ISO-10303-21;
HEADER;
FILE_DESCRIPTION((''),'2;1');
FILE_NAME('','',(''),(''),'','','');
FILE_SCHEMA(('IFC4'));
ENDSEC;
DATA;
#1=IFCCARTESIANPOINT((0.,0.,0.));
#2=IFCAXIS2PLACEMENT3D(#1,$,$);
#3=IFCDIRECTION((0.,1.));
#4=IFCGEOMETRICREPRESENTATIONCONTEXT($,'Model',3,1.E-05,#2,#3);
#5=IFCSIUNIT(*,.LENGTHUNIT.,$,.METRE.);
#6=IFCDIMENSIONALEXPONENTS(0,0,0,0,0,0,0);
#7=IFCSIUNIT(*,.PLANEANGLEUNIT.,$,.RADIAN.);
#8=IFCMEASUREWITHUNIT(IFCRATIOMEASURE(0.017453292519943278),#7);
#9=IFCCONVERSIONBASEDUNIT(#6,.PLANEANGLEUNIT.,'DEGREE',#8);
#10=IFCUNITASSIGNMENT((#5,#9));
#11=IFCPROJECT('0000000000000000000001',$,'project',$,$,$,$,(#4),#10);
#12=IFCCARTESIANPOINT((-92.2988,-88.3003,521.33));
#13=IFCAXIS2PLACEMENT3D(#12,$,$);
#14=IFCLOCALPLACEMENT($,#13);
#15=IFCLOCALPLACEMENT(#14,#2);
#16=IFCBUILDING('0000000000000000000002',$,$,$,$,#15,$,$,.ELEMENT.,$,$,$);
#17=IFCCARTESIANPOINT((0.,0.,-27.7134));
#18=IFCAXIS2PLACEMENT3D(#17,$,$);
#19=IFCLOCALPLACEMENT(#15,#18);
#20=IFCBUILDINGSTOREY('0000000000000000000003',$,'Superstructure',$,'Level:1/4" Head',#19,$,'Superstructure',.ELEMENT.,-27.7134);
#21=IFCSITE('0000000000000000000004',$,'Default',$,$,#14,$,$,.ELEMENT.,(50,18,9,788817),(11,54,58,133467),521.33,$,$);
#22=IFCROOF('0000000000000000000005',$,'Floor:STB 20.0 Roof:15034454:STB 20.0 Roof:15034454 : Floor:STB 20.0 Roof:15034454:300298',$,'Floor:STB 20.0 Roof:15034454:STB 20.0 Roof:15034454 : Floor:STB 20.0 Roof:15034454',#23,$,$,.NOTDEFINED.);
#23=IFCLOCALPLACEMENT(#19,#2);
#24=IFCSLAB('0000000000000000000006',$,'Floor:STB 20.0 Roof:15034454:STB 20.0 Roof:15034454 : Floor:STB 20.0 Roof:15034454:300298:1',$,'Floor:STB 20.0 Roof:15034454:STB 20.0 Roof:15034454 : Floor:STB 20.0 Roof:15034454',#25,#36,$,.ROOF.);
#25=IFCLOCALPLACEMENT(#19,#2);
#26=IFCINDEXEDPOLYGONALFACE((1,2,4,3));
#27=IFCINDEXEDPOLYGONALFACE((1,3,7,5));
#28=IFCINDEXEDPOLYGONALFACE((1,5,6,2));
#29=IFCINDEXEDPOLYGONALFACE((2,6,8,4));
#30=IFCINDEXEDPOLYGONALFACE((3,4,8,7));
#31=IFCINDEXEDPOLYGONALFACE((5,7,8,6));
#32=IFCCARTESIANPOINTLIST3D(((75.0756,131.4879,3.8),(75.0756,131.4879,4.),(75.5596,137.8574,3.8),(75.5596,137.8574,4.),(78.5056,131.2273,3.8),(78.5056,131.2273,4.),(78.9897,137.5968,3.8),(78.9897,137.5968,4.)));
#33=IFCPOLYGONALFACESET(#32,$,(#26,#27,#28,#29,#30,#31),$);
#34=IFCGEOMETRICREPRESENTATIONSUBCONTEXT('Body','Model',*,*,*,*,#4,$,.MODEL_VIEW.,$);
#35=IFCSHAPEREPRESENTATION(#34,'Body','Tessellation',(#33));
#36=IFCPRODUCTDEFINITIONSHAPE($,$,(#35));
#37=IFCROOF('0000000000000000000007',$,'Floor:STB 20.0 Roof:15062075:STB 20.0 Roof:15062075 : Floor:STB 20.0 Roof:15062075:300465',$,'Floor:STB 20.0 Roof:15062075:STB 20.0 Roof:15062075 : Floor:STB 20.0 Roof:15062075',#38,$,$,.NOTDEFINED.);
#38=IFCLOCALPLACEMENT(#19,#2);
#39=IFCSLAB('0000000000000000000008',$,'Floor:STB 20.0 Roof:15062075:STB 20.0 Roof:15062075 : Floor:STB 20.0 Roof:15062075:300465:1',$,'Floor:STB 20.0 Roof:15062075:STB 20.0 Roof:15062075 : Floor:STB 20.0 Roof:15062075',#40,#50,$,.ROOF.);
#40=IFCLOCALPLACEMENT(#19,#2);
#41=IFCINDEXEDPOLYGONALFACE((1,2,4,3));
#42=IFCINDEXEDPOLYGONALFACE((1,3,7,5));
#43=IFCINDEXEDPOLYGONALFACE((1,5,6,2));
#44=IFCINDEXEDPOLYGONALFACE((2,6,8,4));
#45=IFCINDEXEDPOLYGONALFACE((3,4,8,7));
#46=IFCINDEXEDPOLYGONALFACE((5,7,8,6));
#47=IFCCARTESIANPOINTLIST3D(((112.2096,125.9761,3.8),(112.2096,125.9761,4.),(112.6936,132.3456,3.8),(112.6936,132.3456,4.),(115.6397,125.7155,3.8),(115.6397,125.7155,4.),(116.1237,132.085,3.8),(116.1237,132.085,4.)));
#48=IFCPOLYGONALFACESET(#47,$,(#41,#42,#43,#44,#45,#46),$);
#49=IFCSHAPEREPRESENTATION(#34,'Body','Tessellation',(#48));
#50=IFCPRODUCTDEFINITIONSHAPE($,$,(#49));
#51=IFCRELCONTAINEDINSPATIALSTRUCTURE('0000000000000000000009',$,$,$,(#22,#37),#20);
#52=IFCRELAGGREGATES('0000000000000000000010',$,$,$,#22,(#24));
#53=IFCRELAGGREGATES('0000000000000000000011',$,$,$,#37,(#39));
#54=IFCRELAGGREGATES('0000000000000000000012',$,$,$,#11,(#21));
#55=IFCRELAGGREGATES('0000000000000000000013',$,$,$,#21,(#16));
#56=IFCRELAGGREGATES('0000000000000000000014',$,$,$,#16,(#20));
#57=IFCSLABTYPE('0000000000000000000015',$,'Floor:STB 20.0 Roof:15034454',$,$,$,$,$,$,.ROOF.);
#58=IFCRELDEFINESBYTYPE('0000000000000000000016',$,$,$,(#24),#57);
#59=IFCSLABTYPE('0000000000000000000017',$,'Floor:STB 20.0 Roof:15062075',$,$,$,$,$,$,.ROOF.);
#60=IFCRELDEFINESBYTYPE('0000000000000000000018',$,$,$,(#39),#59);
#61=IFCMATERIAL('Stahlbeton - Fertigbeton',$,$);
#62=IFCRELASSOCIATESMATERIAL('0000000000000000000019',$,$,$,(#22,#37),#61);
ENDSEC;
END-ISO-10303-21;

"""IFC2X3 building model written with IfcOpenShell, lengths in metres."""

from ifc_helpers import new_model, entity, si_unit, converted_unit, direction, frame, frame_2d, origin, place, context, subcontext, project, spatial, rectangle, extrude, material, type_object, element, aggregate, save


model = new_model("IFC2X3")

# Units and contexts
model_context = context("Model", 3, precision=1e-05, world=origin(), true_north=direction((0.0, 1.0)))
body_context = subcontext(model_context, "Body", "Model", "MODEL_VIEW")
ifc_project = project(units=[si_unit("LENGTHUNIT", "METRE"), converted_unit("PLANEANGLEUNIT", "DEGREE", entity("IfcRatioMeasure", 0.017453292519943278), si_unit("PLANEANGLEUNIT", "RADIAN"), dimensions=[0, 0, 0, 0, 0, 0, 0])], contexts=[model_context])

# Site, building, storey
site_placement = place(None, frame((-92.2988, -88.3003, 521.33)))
site = spatial("IfcSite", under=ifc_project, at=site_placement, Name="Default", CompositionType="ELEMENT", RefLatitude=(50, 18, 9, 788817), RefLongitude=(11, 54, 58, 133467), RefElevation=521.33)
building_placement = place(site_placement, origin())
building = spatial("IfcBuilding", under=site, at=building_placement, CompositionType="ELEMENT")
storey_placement = place(building_placement, frame((0.0, 0.0, -27.7134)))
storey = spatial("IfcBuildingStorey", under=building, at=storey_placement, Name="Superstructure", ObjectType="Level:1/4\" Head", LongName="Superstructure", CompositionType="ELEMENT", Elevation=-27.7134)

# Roofs, slabs
ifc_material_1 = material(Name="Stahlbeton - Fertigbeton")
roof_1_placement = place(storey_placement, origin())
roof_1 = element("IfcRoof", 1, at=roof_1_placement, inside=storey, material=ifc_material_1, Name="Floor:STB 20.0 Roof:15034454:STB 20.0 Roof:15034454 : Floor:STB 20.0 Roof:15034454:300298", ObjectType="Floor:STB 20.0 Roof:15034454:STB 20.0 Roof:15034454 : Floor:STB 20.0 Roof:15034454", ShapeType="NOTDEFINED")
slab_type_1 = type_object("IfcSlabType", Name="Floor:STB 20.0 Roof:15034454", PredefinedType="ROOF")
slab_1_placement = place(storey_placement, origin())
slab_1 = element("IfcSlab", 2, at=slab_1_placement, type_object=slab_type_1, Name="Floor:STB 20.0 Roof:15034454:STB 20.0 Roof:15034454 : Floor:STB 20.0 Roof:15034454:300298:1", ObjectType="Floor:STB 20.0 Roof:15034454:STB 20.0 Roof:15034454 : Floor:STB 20.0 Roof:15034454", PredefinedType="ROOF", context=body_context, shape_type="SweptSolid", body=[
    extrude(rectangle(XDim=6.3879, YDim=3.4399, at=frame_2d((0.0, 0.0), x_axis=(1.0, 0.0))), frame((77.0326, 134.5424, 3.8), z_axis=(0.0, 0.0, 1.0), x_axis=(0.07577, 0.997125, 0.0)), (0.0, 0.0, 1.0), 0.2),
])
aggregate(roof_1, [slab_1])
roof_2_placement = place(storey_placement, origin())
roof_2 = element("IfcRoof", 3, at=roof_2_placement, inside=storey, material=ifc_material_1, Name="Floor:STB 20.0 Roof:15062075:STB 20.0 Roof:15062075 : Floor:STB 20.0 Roof:15062075:300465", ObjectType="Floor:STB 20.0 Roof:15062075:STB 20.0 Roof:15062075 : Floor:STB 20.0 Roof:15062075", ShapeType="NOTDEFINED")
slab_type_2 = type_object("IfcSlabType", Name="Floor:STB 20.0 Roof:15062075", PredefinedType="ROOF")
slab_2_placement = place(storey_placement, origin())
slab_2 = element("IfcSlab", 4, at=slab_2_placement, type_object=slab_type_2, Name="Floor:STB 20.0 Roof:15062075:STB 20.0 Roof:15062075 : Floor:STB 20.0 Roof:15062075:300465:1", ObjectType="Floor:STB 20.0 Roof:15062075:STB 20.0 Roof:15062075 : Floor:STB 20.0 Roof:15062075", PredefinedType="ROOF", context=body_context, shape_type="SweptSolid", body=[
    extrude(rectangle(XDim=3.4399, YDim=6.3879, at=frame_2d((0.0, 0.0), x_axis=(1.0, 0.0))), frame((114.1666, 129.0305, 3.8), z_axis=(0.0, 0.0, 1.0), x_axis=(-0.997125, 0.07577, 0.0)), (0.0, 0.0, 1.0), 0.2),
])
aggregate(roof_2, [slab_2])

save(model, "model.ifc")
